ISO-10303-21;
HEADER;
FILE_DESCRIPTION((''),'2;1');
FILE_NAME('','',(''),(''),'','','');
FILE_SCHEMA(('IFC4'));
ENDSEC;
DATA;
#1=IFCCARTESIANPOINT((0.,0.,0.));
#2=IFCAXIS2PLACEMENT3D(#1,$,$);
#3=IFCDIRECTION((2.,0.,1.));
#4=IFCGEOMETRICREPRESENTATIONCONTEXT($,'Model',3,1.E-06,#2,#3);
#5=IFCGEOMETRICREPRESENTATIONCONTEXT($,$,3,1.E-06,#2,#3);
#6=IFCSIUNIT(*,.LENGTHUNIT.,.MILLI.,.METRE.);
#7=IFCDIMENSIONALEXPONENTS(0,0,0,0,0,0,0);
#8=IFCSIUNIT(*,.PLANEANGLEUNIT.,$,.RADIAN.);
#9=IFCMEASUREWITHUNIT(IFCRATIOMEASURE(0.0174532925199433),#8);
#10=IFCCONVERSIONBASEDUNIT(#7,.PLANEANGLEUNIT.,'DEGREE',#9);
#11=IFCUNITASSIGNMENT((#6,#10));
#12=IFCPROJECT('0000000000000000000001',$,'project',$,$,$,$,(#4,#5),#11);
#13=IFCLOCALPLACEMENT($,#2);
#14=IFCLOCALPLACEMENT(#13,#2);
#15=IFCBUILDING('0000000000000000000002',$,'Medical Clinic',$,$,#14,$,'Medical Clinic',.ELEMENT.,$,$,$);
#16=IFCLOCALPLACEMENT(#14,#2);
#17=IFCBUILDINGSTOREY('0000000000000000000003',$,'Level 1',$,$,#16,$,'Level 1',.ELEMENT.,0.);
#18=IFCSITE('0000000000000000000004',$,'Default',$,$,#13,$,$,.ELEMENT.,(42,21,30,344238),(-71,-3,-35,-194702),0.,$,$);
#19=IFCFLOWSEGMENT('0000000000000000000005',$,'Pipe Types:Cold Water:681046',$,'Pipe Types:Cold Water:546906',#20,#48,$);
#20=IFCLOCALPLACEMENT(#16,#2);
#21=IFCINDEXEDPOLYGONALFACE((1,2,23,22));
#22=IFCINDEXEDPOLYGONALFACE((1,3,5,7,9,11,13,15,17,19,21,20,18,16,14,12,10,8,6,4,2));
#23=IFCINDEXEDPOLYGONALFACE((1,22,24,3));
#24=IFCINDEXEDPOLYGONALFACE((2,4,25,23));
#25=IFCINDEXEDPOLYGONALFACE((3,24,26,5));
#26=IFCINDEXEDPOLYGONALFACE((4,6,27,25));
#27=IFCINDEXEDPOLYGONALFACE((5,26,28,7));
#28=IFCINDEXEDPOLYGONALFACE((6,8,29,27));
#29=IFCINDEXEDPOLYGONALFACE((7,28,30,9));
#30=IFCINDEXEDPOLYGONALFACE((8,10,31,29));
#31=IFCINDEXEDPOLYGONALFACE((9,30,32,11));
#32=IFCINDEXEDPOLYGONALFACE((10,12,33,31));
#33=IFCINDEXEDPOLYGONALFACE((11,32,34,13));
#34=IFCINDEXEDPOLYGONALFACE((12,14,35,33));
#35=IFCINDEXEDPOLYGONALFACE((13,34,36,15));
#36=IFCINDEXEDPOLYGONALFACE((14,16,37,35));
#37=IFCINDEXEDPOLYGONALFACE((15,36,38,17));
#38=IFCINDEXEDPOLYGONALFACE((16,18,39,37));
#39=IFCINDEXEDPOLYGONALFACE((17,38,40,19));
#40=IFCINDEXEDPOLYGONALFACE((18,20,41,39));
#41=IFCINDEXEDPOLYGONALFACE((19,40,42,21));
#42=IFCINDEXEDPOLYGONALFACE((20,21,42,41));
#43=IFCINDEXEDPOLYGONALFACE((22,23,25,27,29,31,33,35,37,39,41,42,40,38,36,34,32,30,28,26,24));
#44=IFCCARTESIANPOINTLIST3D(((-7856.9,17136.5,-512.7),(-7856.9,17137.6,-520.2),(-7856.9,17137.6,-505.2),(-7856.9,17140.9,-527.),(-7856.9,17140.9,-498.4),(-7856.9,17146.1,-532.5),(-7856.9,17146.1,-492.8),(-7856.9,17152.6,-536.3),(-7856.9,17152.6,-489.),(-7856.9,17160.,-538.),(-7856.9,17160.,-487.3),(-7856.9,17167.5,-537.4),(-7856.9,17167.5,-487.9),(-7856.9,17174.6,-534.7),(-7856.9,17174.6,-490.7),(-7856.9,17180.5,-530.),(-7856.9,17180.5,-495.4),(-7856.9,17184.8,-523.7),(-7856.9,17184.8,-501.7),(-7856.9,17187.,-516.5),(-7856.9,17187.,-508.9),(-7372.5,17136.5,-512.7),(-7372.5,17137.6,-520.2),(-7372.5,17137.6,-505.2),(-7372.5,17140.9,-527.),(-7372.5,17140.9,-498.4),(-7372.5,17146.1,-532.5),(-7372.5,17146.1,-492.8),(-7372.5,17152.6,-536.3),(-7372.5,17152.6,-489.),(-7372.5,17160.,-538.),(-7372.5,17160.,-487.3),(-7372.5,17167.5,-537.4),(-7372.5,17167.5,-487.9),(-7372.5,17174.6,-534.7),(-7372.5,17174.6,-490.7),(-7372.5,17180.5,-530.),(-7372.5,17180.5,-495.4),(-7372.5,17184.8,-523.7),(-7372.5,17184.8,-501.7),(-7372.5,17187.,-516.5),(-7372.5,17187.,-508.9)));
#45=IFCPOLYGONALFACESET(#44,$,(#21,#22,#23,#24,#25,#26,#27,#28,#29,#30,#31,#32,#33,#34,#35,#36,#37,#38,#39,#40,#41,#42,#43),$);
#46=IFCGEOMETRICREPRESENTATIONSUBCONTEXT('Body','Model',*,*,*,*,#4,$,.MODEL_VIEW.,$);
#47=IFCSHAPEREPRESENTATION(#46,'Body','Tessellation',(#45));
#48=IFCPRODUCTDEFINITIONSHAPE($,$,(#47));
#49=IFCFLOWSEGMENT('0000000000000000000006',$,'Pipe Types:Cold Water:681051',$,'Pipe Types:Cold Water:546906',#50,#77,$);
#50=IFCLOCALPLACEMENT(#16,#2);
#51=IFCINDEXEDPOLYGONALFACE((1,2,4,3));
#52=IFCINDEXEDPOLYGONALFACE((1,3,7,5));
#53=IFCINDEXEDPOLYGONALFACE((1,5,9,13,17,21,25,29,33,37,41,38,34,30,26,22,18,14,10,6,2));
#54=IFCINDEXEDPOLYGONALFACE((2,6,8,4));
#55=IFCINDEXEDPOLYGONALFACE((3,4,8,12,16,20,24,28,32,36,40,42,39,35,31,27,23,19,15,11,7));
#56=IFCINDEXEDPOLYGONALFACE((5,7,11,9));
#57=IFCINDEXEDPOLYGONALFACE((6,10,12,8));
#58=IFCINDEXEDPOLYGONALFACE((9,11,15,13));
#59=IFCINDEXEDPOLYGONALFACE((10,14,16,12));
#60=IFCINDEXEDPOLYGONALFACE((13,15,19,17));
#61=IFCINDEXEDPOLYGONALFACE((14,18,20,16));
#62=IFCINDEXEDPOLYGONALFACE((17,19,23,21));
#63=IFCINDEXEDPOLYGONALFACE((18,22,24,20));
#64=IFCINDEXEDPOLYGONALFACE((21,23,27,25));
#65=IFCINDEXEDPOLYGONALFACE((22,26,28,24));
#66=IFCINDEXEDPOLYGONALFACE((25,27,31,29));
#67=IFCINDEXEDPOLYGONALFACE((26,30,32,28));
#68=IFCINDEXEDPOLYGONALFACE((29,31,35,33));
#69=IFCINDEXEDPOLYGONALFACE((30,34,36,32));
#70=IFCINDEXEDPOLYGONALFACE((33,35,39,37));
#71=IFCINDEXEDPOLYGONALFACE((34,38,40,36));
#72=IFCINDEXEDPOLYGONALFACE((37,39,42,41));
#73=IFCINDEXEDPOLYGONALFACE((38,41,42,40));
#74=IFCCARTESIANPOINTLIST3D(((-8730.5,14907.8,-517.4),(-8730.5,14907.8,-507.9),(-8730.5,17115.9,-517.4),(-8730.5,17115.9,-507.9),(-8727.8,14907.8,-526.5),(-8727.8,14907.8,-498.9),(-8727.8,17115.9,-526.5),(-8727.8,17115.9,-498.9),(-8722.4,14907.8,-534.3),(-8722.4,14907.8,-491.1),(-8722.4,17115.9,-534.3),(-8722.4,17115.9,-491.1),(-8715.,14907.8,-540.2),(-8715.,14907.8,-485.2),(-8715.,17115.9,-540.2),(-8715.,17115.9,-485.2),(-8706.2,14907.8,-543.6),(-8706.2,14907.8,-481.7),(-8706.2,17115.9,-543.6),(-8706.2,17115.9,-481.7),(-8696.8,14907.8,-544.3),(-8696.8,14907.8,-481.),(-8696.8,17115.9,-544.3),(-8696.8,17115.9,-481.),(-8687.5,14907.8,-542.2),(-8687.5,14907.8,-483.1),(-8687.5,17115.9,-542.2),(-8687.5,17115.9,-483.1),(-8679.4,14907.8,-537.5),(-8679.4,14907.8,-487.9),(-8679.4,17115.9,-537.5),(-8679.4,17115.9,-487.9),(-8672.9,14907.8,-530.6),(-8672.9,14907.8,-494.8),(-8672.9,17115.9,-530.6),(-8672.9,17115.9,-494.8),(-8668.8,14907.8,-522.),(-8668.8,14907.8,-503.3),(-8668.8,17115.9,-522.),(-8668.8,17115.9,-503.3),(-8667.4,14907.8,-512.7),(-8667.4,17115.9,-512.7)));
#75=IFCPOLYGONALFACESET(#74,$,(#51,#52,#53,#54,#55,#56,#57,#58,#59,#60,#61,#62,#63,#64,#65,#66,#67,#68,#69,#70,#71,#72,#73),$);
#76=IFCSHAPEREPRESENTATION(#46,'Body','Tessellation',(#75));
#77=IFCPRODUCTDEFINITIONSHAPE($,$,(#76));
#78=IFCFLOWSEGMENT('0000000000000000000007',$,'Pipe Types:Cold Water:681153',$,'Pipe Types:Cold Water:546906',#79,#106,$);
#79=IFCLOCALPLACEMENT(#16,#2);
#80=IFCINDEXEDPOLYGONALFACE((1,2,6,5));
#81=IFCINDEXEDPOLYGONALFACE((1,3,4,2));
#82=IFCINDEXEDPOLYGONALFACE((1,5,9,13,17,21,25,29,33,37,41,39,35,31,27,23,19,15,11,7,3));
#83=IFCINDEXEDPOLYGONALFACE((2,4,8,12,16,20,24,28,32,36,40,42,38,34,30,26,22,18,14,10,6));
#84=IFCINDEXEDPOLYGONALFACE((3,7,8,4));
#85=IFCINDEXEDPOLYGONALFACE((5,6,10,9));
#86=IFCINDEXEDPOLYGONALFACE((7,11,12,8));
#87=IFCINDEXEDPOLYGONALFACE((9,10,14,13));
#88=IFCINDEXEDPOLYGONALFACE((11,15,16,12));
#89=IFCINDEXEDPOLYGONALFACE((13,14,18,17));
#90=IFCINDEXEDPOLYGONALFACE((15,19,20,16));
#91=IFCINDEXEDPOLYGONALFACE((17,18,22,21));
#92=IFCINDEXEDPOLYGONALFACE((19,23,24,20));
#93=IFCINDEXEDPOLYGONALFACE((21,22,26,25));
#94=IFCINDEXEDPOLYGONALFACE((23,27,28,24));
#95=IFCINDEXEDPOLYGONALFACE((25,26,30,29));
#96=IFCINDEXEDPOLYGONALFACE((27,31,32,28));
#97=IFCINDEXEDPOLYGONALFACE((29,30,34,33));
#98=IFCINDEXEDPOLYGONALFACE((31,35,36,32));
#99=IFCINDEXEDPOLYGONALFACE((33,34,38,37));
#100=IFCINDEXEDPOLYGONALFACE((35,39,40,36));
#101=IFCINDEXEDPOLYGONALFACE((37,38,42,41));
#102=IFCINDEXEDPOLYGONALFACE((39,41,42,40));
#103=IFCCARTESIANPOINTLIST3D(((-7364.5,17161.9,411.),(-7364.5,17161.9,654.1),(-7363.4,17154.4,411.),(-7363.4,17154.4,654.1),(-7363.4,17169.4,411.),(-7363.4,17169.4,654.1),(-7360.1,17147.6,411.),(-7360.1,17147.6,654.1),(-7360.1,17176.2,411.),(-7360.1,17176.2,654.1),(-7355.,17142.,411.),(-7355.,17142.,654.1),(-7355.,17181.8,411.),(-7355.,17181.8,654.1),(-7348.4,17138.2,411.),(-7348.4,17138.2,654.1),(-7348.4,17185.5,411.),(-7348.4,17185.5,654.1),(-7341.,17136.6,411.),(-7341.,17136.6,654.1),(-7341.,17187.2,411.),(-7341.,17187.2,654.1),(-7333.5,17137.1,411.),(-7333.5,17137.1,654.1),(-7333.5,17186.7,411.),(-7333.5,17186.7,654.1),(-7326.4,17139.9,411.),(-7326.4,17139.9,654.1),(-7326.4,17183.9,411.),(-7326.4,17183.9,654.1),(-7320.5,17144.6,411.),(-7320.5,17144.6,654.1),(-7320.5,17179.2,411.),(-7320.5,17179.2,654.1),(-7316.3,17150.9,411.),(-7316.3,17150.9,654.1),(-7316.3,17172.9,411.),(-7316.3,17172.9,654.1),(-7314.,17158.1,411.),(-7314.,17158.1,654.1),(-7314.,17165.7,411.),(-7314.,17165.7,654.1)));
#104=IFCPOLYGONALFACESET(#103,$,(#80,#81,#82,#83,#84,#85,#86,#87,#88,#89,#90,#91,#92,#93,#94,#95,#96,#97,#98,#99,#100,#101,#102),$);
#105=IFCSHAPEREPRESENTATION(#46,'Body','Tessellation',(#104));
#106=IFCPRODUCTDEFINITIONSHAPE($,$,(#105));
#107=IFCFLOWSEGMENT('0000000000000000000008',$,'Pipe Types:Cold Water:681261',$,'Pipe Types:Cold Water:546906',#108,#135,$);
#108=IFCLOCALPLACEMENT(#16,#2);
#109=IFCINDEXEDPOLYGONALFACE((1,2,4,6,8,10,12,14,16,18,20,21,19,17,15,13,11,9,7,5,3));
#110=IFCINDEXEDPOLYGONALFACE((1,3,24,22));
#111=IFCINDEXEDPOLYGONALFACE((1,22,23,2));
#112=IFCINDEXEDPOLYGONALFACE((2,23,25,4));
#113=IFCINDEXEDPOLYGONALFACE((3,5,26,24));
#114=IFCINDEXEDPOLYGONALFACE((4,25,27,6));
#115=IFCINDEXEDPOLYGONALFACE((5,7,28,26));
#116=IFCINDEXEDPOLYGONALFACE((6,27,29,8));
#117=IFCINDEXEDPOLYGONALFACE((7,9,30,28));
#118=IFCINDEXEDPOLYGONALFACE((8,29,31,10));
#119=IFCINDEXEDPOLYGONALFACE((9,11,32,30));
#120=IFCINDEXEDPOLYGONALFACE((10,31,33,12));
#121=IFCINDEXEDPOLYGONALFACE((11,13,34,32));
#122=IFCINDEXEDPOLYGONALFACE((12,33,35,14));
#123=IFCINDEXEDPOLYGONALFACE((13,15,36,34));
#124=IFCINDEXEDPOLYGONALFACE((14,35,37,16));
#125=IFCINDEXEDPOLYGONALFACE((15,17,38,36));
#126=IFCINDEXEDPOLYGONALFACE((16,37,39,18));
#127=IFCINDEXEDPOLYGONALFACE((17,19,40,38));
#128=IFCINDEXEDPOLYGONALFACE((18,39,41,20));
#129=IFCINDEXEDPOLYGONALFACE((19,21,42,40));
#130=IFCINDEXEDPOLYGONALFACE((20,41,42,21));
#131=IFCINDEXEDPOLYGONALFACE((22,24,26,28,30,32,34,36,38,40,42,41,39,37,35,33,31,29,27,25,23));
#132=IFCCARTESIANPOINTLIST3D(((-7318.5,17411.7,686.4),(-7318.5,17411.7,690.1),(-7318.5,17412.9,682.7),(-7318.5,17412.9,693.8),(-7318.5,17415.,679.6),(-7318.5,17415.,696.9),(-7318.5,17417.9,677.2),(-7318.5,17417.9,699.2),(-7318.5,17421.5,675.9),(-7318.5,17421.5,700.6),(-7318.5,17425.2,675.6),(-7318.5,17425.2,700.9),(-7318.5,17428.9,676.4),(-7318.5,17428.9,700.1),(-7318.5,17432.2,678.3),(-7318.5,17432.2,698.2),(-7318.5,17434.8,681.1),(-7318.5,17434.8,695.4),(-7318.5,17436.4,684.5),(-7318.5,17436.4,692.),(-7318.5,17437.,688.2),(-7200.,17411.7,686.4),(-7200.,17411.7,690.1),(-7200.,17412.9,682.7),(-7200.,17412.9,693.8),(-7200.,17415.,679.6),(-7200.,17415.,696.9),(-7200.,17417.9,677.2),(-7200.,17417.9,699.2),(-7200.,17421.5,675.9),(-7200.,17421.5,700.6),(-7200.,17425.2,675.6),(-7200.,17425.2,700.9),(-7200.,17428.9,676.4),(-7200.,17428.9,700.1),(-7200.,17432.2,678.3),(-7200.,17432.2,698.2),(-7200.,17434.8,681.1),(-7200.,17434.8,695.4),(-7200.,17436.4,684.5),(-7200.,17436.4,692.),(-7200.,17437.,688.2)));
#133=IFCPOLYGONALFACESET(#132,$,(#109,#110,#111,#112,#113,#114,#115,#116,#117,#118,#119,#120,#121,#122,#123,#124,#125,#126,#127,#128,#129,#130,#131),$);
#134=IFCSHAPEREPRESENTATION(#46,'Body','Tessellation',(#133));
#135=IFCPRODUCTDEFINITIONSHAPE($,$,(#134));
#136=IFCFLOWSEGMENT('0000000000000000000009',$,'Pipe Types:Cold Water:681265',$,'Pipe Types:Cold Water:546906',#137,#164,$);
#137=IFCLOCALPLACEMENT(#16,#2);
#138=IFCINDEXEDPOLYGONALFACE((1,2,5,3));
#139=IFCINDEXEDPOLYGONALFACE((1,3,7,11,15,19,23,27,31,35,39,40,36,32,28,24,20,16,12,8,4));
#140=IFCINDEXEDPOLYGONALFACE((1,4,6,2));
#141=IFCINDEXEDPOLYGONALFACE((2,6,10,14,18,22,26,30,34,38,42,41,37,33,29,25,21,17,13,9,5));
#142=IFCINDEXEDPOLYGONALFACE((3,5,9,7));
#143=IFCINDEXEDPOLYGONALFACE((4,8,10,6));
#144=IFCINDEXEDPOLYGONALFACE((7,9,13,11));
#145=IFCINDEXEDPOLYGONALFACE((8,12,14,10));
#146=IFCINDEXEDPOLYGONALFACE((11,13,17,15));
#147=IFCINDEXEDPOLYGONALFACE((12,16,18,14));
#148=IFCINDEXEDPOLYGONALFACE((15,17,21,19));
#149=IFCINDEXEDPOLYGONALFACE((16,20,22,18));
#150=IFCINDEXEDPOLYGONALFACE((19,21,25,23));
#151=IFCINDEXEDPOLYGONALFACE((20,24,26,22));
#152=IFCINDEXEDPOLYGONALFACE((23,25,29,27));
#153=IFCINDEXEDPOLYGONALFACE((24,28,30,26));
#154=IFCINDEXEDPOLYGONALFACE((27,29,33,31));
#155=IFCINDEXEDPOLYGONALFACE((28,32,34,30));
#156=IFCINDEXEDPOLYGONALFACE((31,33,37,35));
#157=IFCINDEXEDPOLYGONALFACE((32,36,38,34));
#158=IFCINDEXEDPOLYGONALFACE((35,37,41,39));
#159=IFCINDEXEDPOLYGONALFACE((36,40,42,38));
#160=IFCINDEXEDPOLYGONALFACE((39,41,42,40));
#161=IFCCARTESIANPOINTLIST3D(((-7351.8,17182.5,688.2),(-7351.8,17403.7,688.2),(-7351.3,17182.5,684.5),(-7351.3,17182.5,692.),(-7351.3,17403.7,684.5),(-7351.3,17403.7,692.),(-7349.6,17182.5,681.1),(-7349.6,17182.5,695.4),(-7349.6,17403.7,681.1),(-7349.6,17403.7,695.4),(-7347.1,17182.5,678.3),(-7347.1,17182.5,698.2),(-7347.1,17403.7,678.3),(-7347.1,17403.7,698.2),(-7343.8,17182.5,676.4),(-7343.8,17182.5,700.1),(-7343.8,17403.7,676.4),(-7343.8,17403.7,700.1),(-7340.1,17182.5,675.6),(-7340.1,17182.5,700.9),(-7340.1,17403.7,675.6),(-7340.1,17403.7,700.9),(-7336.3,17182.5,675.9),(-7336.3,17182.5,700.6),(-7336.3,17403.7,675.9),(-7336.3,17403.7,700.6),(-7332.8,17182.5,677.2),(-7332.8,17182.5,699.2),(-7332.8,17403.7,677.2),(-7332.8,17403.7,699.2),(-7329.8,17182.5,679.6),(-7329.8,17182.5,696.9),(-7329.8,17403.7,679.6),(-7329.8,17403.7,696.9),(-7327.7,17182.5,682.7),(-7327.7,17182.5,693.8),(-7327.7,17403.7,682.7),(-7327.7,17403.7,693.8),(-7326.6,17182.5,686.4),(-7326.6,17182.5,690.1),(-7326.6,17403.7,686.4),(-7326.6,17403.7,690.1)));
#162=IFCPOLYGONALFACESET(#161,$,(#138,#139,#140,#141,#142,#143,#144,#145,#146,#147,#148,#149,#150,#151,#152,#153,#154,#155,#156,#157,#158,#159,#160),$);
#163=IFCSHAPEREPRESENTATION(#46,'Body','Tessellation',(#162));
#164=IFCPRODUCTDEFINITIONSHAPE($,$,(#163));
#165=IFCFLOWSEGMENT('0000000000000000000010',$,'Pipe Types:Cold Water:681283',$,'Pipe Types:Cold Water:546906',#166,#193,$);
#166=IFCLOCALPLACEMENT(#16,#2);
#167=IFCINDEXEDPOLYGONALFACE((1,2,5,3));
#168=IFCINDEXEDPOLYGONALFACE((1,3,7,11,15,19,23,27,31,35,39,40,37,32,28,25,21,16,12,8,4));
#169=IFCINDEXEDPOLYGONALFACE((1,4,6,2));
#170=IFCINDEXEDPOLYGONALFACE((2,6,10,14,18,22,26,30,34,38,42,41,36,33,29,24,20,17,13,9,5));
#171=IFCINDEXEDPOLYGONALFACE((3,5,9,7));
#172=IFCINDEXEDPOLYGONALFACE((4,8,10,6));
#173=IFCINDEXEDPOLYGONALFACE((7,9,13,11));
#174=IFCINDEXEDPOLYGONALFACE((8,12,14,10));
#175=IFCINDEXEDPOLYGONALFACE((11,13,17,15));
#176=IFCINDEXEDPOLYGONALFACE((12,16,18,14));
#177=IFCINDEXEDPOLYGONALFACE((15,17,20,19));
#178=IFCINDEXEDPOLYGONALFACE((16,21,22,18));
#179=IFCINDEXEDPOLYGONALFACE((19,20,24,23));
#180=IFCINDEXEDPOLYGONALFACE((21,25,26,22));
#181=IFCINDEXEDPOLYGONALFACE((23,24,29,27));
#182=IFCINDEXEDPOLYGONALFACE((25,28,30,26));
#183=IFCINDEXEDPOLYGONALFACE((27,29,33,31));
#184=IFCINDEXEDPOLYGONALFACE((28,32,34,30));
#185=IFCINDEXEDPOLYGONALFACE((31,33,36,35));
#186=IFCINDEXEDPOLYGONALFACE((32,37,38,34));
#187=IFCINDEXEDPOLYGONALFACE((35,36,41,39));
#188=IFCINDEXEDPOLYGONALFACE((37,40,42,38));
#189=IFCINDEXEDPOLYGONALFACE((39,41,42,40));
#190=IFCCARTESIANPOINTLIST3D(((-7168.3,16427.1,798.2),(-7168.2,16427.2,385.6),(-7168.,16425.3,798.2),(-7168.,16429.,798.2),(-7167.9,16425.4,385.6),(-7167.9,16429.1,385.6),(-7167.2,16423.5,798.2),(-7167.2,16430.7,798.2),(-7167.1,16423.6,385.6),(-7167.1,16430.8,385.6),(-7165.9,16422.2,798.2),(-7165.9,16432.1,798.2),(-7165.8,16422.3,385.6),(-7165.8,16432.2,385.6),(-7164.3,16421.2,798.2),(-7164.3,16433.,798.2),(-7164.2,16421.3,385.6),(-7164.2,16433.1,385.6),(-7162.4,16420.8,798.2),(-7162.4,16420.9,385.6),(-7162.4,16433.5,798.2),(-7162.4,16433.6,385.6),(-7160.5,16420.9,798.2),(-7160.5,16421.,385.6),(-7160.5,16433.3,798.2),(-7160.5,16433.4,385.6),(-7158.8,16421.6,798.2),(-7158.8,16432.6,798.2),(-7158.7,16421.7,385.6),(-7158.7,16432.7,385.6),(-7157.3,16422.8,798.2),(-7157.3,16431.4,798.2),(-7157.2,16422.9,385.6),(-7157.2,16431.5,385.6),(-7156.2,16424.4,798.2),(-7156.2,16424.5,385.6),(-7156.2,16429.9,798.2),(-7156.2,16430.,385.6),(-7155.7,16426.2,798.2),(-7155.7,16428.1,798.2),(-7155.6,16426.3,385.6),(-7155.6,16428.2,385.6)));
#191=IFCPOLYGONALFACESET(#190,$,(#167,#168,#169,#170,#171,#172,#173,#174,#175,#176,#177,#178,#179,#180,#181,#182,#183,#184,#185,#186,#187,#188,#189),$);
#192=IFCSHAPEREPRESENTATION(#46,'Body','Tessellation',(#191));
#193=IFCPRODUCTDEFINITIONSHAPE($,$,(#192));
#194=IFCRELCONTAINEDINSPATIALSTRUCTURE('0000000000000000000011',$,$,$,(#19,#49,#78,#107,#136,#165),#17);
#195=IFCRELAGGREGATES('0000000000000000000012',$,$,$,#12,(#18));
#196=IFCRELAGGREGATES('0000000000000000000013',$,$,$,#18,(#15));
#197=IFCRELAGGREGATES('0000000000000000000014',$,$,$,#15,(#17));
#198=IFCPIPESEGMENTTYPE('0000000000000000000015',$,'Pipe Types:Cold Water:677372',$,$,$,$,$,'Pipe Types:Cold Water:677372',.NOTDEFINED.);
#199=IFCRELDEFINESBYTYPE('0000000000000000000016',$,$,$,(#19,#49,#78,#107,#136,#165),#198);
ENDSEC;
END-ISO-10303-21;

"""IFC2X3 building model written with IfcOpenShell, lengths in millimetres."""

from ifc_helpers import new_model, entity, si_unit, converted_unit, direction, frame, frame_2d, origin, origin_2d_with_axis, place, context, subcontext, project, spatial, circle, extrude, type_object, element, save


model = new_model("IFC2X3")

# Units and contexts
model_context = context("Model", 3, precision=1e-06, world=origin(), true_north=direction((2.0, 0.0, 1.0)))
context_of_model = context(None, 3, precision=1e-06, world=origin(), true_north=direction((2.0, 0.0, 1.0)))
body_context = subcontext(model_context, "Body", "Model", "MODEL_VIEW")
ifc_project = project(units=[si_unit("LENGTHUNIT", "METRE", prefix="MILLI"), converted_unit("PLANEANGLEUNIT", "DEGREE", entity("IfcRatioMeasure", 0.0174532925199433), si_unit("PLANEANGLEUNIT", "RADIAN"), dimensions=[0, 0, 0, 0, 0, 0, 0])], contexts=[model_context, context_of_model])

# Site, building, storey
site_placement = place(None, origin())
site = spatial("IfcSite", under=ifc_project, at=site_placement, Name="Default", CompositionType="ELEMENT", RefLatitude=(42, 21, 30, 344238), RefLongitude=(-71, -3, -35, -194702), RefElevation=0.0)
building_placement = place(site_placement, origin())
building = spatial("IfcBuilding", under=site, at=building_placement, Name="Medical Clinic", LongName="Medical Clinic", CompositionType="ELEMENT")
storey_placement = place(building_placement, origin())
storey = spatial("IfcBuildingStorey", under=building, at=storey_placement, Name="Level 1", LongName="Level 1", CompositionType="ELEMENT", Elevation=0.0)

# Flow segments
pipe_segment_type_1 = type_object("IfcPipeSegmentType", Name="Pipe Types:Cold Water:677372", ElementType="Pipe Types:Cold Water:677372", PredefinedType="NOTDEFINED")
flow_segment_1_placement = place(storey_placement, origin())
element("IfcFlowSegment", 1, at=flow_segment_1_placement, inside=storey, type_object=pipe_segment_type_1, Name="Pipe Types:Cold Water:681046", ObjectType="Pipe Types:Cold Water:546906", context=body_context, shape_type="SweptSolid", body=[
    extrude(circle(Radius=25.4, at=origin_2d_with_axis()), frame((-7856.9, 17161.9, -512.7), z_axis=(1.0, 0.0, 0.0), x_axis=(0.0, -1.0, 0.0)), (0.0, 0.0, 1.0), 484.5),
])
flow_segment_2_placement = place(storey_placement, origin())
element("IfcFlowSegment", 2, at=flow_segment_2_placement, inside=storey, type_object=pipe_segment_type_1, Name="Pipe Types:Cold Water:681051", ObjectType="Pipe Types:Cold Water:546906", context=body_context, shape_type="SweptSolid", body=[
    extrude(circle(Radius=31.8, at=frame_2d((0.0, 0.0), x_axis=(1.0, 0.0))), frame((-8699.1, 14907.8, -512.7), z_axis=(0.0, 1.0, 0.0), x_axis=(1.0, 0.0, 0.0)), (0.0, 0.0, 1.0), 2208.0),
])
flow_segment_3_placement = place(storey_placement, origin())
element("IfcFlowSegment", 3, at=flow_segment_3_placement, inside=storey, type_object=pipe_segment_type_1, Name="Pipe Types:Cold Water:681153", ObjectType="Pipe Types:Cold Water:546906", context=body_context, shape_type="SweptSolid", body=[
    extrude(circle(Radius=25.4, at=origin_2d_with_axis()), frame((-7339.1, 17161.9, 411.0), z_axis=(0.0, 0.0, 1.0), x_axis=(-1.0, 0.0, 0.0)), (0.0, 0.0, 1.0), 243.2),
])
flow_segment_4_placement = place(storey_placement, origin())
element("IfcFlowSegment", 4, at=flow_segment_4_placement, inside=storey, type_object=pipe_segment_type_1, Name="Pipe Types:Cold Water:681261", ObjectType="Pipe Types:Cold Water:546906", context=body_context, shape_type="SweptSolid", body=[
    extrude(circle(Radius=12.7, at=frame_2d((0.0, 0.0), x_axis=(1.0, 0.0))), frame((-7318.5, 17424.3, 688.2), z_axis=(1.0, 0.0, 0.0), x_axis=(0.0, 1.0, 0.0)), (0.0, 0.0, 1.0), 118.5),
])
flow_segment_5_placement = place(storey_placement, origin())
element("IfcFlowSegment", 5, at=flow_segment_5_placement, inside=storey, type_object=pipe_segment_type_1, Name="Pipe Types:Cold Water:681265", ObjectType="Pipe Types:Cold Water:546906", context=body_context, shape_type="SweptSolid", body=[
    extrude(circle(Radius=12.7, at=frame_2d((0.0, 0.0), x_axis=(1.0, 0.0))), frame((-7339.1, 17182.5, 688.2), z_axis=(0.0, 1.0, 0.0), x_axis=(-1.0, 0.0, 0.0)), (0.0, 0.0, 1.0), 221.1),
])
flow_segment_6_placement = place(storey_placement, origin())
element("IfcFlowSegment", 6, at=flow_segment_6_placement, inside=storey, type_object=pipe_segment_type_1, Name="Pipe Types:Cold Water:681283", ObjectType="Pipe Types:Cold Water:546906", context=body_context, shape_type="SweptSolid", body=[
    extrude(circle(Radius=6.3, at=frame_2d((0.0, 0.0), x_axis=(1.0, 0.0))), frame((-7161.9, 16427.2, 385.6), z_axis=(-0.000201, -0.000244, 1.0), x_axis=(-1.0, 0.0, -0.000201)), (0.0, 0.0, 1.0), 412.7),
])

save(model, "model.ifc")
